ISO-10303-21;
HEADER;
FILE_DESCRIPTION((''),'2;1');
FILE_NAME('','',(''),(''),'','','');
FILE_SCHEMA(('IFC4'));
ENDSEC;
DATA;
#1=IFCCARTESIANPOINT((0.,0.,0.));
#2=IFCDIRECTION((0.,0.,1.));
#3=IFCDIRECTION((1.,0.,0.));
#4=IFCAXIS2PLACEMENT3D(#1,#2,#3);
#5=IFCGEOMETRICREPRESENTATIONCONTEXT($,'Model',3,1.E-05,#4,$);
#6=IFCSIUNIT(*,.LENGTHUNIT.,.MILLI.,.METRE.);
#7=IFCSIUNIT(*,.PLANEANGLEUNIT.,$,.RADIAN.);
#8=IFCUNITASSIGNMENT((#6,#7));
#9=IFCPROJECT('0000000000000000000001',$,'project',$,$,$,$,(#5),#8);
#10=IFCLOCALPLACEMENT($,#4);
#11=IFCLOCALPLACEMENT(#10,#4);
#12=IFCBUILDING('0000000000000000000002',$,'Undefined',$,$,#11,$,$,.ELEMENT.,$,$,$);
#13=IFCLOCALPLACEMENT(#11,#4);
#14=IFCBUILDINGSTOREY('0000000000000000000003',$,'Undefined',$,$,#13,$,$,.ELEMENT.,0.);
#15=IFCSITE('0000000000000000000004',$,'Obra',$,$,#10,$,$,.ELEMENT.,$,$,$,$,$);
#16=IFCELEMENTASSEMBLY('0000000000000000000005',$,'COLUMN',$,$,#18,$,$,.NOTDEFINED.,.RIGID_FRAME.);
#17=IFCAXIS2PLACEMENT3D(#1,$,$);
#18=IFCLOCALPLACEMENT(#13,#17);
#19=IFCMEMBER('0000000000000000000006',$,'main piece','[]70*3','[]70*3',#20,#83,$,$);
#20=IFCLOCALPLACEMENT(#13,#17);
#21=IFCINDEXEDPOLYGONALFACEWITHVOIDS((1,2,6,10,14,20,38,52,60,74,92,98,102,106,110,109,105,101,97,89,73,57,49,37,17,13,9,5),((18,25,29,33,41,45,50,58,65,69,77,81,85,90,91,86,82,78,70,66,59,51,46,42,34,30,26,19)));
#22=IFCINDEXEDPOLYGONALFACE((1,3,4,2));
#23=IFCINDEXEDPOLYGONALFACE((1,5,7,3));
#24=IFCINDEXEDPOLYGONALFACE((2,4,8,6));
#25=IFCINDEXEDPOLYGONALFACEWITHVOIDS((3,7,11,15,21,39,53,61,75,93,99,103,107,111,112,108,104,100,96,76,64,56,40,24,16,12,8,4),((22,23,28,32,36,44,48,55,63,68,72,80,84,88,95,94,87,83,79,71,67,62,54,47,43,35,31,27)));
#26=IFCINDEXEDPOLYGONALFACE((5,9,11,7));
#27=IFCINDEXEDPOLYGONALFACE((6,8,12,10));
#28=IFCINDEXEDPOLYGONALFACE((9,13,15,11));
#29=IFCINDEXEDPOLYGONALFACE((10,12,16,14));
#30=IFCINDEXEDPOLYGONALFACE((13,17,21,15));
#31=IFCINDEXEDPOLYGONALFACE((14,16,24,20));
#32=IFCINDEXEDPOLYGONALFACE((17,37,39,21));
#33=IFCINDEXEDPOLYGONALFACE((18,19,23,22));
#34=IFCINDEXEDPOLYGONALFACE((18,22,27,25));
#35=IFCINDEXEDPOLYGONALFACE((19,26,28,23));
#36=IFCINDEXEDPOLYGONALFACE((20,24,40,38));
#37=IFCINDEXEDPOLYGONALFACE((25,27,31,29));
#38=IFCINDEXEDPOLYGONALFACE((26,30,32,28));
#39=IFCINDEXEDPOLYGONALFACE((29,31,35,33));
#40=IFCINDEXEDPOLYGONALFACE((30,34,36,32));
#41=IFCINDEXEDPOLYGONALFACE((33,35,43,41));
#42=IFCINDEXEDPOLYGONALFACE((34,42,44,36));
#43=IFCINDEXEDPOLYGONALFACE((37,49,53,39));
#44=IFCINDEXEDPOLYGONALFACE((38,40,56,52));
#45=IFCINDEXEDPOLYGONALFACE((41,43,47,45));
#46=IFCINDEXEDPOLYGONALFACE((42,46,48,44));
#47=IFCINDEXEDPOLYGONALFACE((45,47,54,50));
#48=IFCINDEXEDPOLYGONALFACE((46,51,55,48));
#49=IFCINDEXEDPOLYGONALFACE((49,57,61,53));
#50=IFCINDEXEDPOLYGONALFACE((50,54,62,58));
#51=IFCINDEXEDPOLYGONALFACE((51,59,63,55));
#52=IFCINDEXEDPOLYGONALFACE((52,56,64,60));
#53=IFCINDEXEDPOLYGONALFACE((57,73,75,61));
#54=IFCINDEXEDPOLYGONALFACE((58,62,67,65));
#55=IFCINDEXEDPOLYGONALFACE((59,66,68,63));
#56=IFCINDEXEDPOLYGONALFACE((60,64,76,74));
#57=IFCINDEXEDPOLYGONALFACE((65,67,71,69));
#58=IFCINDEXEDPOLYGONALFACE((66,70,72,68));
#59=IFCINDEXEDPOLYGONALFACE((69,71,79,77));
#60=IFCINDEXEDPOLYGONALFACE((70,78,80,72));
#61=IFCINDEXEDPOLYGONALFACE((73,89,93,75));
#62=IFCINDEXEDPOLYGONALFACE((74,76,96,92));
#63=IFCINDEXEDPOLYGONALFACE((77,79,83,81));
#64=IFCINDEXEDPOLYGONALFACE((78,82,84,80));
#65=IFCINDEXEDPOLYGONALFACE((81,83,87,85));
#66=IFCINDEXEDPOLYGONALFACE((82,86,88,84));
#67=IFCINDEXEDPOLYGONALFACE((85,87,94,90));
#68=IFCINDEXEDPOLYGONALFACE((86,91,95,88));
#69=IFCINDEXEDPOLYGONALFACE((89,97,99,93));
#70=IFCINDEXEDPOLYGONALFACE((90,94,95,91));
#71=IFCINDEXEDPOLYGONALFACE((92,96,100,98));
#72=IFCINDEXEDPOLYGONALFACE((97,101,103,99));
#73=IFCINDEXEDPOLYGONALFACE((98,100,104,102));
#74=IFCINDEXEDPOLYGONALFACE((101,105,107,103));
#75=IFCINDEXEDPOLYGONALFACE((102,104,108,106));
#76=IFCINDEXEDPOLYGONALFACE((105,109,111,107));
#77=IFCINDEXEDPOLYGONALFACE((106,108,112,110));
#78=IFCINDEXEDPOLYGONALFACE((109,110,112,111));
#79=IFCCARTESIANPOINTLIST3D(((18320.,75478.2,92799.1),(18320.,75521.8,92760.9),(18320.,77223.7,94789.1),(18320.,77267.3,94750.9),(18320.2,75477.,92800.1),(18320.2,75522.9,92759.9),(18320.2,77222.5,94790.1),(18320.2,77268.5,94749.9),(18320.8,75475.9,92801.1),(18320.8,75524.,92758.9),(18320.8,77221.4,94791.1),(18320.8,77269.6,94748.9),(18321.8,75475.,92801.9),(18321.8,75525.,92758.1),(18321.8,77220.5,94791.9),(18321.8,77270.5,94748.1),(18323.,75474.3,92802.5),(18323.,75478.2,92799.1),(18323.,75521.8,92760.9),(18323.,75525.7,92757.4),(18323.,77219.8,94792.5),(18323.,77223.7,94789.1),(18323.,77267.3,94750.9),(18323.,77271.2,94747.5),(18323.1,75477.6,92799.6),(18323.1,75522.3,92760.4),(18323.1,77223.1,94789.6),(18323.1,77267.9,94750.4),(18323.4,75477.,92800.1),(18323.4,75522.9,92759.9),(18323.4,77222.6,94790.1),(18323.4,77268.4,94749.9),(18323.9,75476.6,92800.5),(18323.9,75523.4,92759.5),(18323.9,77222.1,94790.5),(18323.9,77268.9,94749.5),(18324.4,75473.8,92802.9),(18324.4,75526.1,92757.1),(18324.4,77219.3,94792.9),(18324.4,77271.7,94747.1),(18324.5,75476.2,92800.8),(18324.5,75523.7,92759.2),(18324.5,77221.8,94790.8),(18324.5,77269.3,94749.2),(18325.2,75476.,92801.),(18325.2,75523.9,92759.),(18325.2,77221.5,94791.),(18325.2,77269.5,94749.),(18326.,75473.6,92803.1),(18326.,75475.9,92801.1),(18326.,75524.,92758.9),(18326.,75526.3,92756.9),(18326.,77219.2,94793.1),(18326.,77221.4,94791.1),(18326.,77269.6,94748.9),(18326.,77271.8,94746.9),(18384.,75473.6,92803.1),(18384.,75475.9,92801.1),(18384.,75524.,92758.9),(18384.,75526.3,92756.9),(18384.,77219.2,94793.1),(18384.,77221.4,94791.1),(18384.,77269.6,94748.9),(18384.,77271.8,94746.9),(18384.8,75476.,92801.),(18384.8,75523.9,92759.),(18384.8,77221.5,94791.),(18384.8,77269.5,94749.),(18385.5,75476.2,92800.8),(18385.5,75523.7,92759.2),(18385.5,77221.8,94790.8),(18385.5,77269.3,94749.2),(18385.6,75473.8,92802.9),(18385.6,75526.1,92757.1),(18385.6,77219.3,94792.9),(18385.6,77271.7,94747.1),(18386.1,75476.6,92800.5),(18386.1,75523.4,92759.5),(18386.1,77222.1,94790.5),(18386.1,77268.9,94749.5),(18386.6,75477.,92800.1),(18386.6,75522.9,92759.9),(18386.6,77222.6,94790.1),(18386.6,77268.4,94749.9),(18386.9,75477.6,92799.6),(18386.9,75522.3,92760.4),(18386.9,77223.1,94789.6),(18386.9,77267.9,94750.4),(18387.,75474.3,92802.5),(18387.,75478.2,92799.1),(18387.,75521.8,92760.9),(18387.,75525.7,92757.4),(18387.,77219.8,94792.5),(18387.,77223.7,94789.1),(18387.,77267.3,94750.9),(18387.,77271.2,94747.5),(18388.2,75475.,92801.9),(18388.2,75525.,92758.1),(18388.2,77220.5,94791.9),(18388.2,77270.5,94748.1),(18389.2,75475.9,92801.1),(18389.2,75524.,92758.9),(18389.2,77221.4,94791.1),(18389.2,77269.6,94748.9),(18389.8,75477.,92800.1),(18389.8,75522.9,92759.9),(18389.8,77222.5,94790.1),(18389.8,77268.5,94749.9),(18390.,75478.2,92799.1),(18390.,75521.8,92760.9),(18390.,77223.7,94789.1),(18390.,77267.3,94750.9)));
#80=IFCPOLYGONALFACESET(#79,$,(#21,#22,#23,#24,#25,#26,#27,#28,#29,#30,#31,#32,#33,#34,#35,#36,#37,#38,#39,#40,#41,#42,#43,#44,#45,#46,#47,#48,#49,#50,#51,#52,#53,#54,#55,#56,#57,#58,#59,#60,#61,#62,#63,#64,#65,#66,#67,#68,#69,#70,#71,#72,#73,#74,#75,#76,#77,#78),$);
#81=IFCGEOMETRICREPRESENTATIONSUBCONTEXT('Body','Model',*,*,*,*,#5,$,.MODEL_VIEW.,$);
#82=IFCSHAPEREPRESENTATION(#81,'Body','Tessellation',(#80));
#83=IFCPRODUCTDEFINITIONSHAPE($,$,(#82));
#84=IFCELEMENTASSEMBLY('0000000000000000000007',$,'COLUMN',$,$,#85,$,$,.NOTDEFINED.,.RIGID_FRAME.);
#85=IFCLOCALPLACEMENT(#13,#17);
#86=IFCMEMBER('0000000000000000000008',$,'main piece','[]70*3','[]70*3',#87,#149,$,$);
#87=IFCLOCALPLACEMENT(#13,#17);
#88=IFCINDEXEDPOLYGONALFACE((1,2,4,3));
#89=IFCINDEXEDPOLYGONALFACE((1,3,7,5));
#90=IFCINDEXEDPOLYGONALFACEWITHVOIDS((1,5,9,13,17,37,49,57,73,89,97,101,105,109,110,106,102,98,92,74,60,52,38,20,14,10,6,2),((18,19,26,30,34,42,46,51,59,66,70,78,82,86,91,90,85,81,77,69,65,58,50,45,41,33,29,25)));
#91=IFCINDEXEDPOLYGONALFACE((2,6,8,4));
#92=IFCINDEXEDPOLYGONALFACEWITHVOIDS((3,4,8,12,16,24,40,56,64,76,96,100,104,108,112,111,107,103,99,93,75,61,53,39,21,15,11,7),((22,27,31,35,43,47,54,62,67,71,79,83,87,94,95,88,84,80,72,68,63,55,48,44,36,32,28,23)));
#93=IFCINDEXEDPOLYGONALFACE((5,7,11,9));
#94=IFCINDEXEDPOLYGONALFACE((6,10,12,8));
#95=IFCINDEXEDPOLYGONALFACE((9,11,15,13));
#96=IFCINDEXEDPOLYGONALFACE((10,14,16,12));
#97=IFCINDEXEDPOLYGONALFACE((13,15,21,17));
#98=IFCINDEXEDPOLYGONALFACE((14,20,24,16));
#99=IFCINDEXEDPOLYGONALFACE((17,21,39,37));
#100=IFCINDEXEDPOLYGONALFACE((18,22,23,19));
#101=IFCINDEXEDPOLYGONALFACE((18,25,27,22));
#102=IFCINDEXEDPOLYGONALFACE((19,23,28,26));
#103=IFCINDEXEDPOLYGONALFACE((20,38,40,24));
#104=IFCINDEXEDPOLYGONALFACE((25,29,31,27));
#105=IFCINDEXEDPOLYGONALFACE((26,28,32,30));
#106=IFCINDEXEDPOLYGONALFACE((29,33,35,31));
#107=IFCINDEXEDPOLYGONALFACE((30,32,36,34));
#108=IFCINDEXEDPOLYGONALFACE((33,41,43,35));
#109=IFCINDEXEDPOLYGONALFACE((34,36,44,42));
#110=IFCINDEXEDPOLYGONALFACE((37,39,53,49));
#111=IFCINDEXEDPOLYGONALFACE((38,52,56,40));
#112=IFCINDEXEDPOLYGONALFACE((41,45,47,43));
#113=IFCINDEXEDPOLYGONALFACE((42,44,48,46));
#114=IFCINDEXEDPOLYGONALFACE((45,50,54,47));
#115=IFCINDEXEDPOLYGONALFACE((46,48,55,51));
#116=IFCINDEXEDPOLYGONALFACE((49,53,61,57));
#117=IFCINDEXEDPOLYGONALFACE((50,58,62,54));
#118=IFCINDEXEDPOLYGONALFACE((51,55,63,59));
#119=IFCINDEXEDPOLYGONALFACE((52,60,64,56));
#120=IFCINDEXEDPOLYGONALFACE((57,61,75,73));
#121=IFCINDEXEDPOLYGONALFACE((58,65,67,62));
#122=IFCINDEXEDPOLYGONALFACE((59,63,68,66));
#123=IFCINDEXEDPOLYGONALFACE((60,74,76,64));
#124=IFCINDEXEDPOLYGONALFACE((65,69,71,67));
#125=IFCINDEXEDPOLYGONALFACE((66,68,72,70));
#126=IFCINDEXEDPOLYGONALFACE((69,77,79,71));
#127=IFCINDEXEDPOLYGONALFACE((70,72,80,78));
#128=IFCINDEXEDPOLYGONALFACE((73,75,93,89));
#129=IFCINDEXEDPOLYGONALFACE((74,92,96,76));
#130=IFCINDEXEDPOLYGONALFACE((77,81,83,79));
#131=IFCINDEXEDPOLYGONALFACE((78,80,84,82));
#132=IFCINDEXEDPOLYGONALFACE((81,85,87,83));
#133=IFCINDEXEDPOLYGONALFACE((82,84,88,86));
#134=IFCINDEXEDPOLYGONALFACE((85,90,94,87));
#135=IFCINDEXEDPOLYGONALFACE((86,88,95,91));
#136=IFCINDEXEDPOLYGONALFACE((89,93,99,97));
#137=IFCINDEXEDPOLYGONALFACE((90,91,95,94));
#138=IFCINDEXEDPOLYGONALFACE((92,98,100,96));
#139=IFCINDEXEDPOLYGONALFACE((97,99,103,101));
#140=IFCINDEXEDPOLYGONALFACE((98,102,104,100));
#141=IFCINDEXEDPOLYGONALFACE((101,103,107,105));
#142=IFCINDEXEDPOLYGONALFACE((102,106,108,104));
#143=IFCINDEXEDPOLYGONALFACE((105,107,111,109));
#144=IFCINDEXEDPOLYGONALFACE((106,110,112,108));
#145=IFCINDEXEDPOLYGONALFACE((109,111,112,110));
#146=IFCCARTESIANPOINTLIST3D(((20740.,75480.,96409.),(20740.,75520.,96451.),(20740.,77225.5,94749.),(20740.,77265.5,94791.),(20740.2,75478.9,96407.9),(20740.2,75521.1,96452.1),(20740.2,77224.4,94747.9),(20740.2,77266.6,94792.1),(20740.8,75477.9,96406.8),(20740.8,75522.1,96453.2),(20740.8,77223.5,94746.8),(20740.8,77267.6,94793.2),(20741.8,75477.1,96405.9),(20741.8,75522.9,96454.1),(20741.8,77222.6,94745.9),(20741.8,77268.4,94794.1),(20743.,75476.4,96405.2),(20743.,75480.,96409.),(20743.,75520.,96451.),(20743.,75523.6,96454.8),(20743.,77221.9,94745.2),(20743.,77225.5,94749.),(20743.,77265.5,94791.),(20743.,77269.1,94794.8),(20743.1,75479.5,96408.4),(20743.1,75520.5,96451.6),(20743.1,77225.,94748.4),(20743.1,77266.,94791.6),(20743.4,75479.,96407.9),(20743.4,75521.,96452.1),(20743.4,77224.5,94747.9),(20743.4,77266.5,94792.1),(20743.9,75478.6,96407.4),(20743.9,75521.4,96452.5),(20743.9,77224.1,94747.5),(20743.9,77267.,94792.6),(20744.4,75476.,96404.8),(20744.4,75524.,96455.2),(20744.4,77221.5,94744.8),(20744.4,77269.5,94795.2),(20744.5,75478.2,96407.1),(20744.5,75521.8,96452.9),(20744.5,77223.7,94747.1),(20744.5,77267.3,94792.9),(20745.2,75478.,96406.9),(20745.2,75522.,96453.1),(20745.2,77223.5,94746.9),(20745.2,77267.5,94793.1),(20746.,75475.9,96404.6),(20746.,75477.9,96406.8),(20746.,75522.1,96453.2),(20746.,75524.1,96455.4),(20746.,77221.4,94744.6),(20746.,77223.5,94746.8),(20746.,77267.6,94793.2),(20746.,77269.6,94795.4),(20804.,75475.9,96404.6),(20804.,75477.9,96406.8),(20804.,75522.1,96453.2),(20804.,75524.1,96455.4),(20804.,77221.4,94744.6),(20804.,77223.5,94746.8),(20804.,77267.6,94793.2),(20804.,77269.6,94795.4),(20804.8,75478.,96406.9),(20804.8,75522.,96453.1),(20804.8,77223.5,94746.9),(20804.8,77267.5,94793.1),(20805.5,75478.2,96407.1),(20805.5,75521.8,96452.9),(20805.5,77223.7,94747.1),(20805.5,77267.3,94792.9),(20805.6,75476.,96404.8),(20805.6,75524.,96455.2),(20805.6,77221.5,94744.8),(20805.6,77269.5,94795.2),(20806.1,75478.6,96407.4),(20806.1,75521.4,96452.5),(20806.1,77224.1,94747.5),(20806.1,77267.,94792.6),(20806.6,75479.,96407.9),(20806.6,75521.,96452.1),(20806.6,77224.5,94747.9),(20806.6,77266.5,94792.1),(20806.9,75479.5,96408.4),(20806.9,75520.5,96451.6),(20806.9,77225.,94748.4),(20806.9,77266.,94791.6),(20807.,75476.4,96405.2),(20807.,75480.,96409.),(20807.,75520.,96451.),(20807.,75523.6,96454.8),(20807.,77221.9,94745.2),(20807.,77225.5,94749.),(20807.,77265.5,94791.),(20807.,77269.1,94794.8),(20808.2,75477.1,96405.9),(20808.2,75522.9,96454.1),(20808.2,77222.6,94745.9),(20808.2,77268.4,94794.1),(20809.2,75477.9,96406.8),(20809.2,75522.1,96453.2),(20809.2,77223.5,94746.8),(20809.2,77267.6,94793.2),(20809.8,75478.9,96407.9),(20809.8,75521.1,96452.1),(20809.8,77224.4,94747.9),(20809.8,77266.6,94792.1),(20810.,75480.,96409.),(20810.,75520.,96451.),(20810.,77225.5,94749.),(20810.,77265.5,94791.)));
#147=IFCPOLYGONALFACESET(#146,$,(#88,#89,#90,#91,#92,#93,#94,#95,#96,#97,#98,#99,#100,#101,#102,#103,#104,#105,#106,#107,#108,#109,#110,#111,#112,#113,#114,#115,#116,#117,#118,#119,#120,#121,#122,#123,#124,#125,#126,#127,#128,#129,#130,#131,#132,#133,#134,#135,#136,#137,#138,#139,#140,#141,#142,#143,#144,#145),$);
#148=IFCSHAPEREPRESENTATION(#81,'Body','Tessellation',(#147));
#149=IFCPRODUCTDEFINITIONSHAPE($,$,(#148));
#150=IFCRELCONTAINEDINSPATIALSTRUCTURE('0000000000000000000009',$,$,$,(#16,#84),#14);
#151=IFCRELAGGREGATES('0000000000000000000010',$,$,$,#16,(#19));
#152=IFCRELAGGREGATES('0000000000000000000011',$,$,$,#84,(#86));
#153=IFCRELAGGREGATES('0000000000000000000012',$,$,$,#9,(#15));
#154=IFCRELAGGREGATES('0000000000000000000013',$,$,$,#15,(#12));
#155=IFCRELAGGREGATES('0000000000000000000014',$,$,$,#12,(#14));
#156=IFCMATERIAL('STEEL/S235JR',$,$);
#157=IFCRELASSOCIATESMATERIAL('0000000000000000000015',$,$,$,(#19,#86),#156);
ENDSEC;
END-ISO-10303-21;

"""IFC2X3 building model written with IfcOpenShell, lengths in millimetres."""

from ifc_helpers import new_model, si_unit, frame, origin_with_axes, origin_2d_with_axis, place, context, subcontext, project, spatial, hollow_rectangle, extrude, material, element, aggregate, save


model = new_model("IFC2X3")

# Units and contexts
model_context = context("Model", 3, precision=1e-05, world=origin_with_axes())
body_context = subcontext(model_context, "Body", "Model", "MODEL_VIEW")
ifc_project = project(units=[si_unit("LENGTHUNIT", "METRE", prefix="MILLI"), si_unit("PLANEANGLEUNIT", "RADIAN")], contexts=[model_context])

# Site, building, storey
site_placement = place(None, origin_with_axes())
site = spatial("IfcSite", under=ifc_project, at=site_placement, Name="Obra", CompositionType="ELEMENT")
building_placement = place(site_placement, origin_with_axes())
building = spatial("IfcBuilding", under=site, at=building_placement, Name="Undefined", CompositionType="ELEMENT")
storey_placement = place(building_placement, origin_with_axes())
storey = spatial("IfcBuildingStorey", under=building, at=storey_placement, Name="Undefined", CompositionType="ELEMENT", Elevation=0.0)

# Shared definitions
ifc_material = material(Name="STEEL/S235JR")

# Element assemblies, members
assembly_1_placement = place(storey_placement, origin_with_axes())
assembly_1 = element("IfcElementAssembly", 1, at=assembly_1_placement, inside=storey, Name="COLUMN", AssemblyPlace="NOTDEFINED", PredefinedType="RIGID_FRAME")
member_1_placement = place(assembly_1_placement, frame((18355.0, 75500.0, 92780.0), z_axis=(-1.0, 0.0, 0.0), x_axis=(0.0, 0.659423, 0.751772)))
member_1 = element("IfcMember", 2, at=member_1_placement, material=ifc_material, Name="main piece", Description="[]70*3", ObjectType="[]70*3", context=body_context, shape_type="SweptSolid", body=[
    extrude(hollow_rectangle(XDim=70.0, YDim=70.0, WallThickness=3.0, InnerFilletRadius=3.0, OuterFilletRadius=6.0, at=origin_2d_with_axis()), frame((2647.1, 0.0, 0.0), z_axis=(-1.0, 0.0, 0.0), x_axis=(0.0, -1.0, 0.0)), (0.0, 0.0, 1.0), 2647.1),
])
aggregate(assembly_1, [member_1])
assembly_2_placement = place(storey_placement, origin_with_axes())
assembly_2 = element("IfcElementAssembly", 3, at=assembly_2_placement, inside=storey, Name="COLUMN", AssemblyPlace="NOTDEFINED", PredefinedType="RIGID_FRAME")
member_2_placement = place(assembly_2_placement, frame((20775.0, 77245.5, 94770.0), z_axis=(1.0, 0.0, 0.0), x_axis=(0.0, -0.724633, 0.689135)))
member_2 = element("IfcMember", 4, at=member_2_placement, material=ifc_material, Name="main piece", Description="[]70*3", ObjectType="[]70*3", context=body_context, shape_type="SweptSolid", body=[
    extrude(hollow_rectangle(XDim=70.0, YDim=70.0, WallThickness=3.0, InnerFilletRadius=3.0, OuterFilletRadius=6.0, at=origin_2d_with_axis()), frame((2408.8, 0.0, 0.0), z_axis=(-1.0, 0.0, 0.0), x_axis=(0.0, -1.0, 0.0)), (0.0, 0.0, 1.0), 2408.8),
])
aggregate(assembly_2, [member_2])

save(model, "model.ifc")
